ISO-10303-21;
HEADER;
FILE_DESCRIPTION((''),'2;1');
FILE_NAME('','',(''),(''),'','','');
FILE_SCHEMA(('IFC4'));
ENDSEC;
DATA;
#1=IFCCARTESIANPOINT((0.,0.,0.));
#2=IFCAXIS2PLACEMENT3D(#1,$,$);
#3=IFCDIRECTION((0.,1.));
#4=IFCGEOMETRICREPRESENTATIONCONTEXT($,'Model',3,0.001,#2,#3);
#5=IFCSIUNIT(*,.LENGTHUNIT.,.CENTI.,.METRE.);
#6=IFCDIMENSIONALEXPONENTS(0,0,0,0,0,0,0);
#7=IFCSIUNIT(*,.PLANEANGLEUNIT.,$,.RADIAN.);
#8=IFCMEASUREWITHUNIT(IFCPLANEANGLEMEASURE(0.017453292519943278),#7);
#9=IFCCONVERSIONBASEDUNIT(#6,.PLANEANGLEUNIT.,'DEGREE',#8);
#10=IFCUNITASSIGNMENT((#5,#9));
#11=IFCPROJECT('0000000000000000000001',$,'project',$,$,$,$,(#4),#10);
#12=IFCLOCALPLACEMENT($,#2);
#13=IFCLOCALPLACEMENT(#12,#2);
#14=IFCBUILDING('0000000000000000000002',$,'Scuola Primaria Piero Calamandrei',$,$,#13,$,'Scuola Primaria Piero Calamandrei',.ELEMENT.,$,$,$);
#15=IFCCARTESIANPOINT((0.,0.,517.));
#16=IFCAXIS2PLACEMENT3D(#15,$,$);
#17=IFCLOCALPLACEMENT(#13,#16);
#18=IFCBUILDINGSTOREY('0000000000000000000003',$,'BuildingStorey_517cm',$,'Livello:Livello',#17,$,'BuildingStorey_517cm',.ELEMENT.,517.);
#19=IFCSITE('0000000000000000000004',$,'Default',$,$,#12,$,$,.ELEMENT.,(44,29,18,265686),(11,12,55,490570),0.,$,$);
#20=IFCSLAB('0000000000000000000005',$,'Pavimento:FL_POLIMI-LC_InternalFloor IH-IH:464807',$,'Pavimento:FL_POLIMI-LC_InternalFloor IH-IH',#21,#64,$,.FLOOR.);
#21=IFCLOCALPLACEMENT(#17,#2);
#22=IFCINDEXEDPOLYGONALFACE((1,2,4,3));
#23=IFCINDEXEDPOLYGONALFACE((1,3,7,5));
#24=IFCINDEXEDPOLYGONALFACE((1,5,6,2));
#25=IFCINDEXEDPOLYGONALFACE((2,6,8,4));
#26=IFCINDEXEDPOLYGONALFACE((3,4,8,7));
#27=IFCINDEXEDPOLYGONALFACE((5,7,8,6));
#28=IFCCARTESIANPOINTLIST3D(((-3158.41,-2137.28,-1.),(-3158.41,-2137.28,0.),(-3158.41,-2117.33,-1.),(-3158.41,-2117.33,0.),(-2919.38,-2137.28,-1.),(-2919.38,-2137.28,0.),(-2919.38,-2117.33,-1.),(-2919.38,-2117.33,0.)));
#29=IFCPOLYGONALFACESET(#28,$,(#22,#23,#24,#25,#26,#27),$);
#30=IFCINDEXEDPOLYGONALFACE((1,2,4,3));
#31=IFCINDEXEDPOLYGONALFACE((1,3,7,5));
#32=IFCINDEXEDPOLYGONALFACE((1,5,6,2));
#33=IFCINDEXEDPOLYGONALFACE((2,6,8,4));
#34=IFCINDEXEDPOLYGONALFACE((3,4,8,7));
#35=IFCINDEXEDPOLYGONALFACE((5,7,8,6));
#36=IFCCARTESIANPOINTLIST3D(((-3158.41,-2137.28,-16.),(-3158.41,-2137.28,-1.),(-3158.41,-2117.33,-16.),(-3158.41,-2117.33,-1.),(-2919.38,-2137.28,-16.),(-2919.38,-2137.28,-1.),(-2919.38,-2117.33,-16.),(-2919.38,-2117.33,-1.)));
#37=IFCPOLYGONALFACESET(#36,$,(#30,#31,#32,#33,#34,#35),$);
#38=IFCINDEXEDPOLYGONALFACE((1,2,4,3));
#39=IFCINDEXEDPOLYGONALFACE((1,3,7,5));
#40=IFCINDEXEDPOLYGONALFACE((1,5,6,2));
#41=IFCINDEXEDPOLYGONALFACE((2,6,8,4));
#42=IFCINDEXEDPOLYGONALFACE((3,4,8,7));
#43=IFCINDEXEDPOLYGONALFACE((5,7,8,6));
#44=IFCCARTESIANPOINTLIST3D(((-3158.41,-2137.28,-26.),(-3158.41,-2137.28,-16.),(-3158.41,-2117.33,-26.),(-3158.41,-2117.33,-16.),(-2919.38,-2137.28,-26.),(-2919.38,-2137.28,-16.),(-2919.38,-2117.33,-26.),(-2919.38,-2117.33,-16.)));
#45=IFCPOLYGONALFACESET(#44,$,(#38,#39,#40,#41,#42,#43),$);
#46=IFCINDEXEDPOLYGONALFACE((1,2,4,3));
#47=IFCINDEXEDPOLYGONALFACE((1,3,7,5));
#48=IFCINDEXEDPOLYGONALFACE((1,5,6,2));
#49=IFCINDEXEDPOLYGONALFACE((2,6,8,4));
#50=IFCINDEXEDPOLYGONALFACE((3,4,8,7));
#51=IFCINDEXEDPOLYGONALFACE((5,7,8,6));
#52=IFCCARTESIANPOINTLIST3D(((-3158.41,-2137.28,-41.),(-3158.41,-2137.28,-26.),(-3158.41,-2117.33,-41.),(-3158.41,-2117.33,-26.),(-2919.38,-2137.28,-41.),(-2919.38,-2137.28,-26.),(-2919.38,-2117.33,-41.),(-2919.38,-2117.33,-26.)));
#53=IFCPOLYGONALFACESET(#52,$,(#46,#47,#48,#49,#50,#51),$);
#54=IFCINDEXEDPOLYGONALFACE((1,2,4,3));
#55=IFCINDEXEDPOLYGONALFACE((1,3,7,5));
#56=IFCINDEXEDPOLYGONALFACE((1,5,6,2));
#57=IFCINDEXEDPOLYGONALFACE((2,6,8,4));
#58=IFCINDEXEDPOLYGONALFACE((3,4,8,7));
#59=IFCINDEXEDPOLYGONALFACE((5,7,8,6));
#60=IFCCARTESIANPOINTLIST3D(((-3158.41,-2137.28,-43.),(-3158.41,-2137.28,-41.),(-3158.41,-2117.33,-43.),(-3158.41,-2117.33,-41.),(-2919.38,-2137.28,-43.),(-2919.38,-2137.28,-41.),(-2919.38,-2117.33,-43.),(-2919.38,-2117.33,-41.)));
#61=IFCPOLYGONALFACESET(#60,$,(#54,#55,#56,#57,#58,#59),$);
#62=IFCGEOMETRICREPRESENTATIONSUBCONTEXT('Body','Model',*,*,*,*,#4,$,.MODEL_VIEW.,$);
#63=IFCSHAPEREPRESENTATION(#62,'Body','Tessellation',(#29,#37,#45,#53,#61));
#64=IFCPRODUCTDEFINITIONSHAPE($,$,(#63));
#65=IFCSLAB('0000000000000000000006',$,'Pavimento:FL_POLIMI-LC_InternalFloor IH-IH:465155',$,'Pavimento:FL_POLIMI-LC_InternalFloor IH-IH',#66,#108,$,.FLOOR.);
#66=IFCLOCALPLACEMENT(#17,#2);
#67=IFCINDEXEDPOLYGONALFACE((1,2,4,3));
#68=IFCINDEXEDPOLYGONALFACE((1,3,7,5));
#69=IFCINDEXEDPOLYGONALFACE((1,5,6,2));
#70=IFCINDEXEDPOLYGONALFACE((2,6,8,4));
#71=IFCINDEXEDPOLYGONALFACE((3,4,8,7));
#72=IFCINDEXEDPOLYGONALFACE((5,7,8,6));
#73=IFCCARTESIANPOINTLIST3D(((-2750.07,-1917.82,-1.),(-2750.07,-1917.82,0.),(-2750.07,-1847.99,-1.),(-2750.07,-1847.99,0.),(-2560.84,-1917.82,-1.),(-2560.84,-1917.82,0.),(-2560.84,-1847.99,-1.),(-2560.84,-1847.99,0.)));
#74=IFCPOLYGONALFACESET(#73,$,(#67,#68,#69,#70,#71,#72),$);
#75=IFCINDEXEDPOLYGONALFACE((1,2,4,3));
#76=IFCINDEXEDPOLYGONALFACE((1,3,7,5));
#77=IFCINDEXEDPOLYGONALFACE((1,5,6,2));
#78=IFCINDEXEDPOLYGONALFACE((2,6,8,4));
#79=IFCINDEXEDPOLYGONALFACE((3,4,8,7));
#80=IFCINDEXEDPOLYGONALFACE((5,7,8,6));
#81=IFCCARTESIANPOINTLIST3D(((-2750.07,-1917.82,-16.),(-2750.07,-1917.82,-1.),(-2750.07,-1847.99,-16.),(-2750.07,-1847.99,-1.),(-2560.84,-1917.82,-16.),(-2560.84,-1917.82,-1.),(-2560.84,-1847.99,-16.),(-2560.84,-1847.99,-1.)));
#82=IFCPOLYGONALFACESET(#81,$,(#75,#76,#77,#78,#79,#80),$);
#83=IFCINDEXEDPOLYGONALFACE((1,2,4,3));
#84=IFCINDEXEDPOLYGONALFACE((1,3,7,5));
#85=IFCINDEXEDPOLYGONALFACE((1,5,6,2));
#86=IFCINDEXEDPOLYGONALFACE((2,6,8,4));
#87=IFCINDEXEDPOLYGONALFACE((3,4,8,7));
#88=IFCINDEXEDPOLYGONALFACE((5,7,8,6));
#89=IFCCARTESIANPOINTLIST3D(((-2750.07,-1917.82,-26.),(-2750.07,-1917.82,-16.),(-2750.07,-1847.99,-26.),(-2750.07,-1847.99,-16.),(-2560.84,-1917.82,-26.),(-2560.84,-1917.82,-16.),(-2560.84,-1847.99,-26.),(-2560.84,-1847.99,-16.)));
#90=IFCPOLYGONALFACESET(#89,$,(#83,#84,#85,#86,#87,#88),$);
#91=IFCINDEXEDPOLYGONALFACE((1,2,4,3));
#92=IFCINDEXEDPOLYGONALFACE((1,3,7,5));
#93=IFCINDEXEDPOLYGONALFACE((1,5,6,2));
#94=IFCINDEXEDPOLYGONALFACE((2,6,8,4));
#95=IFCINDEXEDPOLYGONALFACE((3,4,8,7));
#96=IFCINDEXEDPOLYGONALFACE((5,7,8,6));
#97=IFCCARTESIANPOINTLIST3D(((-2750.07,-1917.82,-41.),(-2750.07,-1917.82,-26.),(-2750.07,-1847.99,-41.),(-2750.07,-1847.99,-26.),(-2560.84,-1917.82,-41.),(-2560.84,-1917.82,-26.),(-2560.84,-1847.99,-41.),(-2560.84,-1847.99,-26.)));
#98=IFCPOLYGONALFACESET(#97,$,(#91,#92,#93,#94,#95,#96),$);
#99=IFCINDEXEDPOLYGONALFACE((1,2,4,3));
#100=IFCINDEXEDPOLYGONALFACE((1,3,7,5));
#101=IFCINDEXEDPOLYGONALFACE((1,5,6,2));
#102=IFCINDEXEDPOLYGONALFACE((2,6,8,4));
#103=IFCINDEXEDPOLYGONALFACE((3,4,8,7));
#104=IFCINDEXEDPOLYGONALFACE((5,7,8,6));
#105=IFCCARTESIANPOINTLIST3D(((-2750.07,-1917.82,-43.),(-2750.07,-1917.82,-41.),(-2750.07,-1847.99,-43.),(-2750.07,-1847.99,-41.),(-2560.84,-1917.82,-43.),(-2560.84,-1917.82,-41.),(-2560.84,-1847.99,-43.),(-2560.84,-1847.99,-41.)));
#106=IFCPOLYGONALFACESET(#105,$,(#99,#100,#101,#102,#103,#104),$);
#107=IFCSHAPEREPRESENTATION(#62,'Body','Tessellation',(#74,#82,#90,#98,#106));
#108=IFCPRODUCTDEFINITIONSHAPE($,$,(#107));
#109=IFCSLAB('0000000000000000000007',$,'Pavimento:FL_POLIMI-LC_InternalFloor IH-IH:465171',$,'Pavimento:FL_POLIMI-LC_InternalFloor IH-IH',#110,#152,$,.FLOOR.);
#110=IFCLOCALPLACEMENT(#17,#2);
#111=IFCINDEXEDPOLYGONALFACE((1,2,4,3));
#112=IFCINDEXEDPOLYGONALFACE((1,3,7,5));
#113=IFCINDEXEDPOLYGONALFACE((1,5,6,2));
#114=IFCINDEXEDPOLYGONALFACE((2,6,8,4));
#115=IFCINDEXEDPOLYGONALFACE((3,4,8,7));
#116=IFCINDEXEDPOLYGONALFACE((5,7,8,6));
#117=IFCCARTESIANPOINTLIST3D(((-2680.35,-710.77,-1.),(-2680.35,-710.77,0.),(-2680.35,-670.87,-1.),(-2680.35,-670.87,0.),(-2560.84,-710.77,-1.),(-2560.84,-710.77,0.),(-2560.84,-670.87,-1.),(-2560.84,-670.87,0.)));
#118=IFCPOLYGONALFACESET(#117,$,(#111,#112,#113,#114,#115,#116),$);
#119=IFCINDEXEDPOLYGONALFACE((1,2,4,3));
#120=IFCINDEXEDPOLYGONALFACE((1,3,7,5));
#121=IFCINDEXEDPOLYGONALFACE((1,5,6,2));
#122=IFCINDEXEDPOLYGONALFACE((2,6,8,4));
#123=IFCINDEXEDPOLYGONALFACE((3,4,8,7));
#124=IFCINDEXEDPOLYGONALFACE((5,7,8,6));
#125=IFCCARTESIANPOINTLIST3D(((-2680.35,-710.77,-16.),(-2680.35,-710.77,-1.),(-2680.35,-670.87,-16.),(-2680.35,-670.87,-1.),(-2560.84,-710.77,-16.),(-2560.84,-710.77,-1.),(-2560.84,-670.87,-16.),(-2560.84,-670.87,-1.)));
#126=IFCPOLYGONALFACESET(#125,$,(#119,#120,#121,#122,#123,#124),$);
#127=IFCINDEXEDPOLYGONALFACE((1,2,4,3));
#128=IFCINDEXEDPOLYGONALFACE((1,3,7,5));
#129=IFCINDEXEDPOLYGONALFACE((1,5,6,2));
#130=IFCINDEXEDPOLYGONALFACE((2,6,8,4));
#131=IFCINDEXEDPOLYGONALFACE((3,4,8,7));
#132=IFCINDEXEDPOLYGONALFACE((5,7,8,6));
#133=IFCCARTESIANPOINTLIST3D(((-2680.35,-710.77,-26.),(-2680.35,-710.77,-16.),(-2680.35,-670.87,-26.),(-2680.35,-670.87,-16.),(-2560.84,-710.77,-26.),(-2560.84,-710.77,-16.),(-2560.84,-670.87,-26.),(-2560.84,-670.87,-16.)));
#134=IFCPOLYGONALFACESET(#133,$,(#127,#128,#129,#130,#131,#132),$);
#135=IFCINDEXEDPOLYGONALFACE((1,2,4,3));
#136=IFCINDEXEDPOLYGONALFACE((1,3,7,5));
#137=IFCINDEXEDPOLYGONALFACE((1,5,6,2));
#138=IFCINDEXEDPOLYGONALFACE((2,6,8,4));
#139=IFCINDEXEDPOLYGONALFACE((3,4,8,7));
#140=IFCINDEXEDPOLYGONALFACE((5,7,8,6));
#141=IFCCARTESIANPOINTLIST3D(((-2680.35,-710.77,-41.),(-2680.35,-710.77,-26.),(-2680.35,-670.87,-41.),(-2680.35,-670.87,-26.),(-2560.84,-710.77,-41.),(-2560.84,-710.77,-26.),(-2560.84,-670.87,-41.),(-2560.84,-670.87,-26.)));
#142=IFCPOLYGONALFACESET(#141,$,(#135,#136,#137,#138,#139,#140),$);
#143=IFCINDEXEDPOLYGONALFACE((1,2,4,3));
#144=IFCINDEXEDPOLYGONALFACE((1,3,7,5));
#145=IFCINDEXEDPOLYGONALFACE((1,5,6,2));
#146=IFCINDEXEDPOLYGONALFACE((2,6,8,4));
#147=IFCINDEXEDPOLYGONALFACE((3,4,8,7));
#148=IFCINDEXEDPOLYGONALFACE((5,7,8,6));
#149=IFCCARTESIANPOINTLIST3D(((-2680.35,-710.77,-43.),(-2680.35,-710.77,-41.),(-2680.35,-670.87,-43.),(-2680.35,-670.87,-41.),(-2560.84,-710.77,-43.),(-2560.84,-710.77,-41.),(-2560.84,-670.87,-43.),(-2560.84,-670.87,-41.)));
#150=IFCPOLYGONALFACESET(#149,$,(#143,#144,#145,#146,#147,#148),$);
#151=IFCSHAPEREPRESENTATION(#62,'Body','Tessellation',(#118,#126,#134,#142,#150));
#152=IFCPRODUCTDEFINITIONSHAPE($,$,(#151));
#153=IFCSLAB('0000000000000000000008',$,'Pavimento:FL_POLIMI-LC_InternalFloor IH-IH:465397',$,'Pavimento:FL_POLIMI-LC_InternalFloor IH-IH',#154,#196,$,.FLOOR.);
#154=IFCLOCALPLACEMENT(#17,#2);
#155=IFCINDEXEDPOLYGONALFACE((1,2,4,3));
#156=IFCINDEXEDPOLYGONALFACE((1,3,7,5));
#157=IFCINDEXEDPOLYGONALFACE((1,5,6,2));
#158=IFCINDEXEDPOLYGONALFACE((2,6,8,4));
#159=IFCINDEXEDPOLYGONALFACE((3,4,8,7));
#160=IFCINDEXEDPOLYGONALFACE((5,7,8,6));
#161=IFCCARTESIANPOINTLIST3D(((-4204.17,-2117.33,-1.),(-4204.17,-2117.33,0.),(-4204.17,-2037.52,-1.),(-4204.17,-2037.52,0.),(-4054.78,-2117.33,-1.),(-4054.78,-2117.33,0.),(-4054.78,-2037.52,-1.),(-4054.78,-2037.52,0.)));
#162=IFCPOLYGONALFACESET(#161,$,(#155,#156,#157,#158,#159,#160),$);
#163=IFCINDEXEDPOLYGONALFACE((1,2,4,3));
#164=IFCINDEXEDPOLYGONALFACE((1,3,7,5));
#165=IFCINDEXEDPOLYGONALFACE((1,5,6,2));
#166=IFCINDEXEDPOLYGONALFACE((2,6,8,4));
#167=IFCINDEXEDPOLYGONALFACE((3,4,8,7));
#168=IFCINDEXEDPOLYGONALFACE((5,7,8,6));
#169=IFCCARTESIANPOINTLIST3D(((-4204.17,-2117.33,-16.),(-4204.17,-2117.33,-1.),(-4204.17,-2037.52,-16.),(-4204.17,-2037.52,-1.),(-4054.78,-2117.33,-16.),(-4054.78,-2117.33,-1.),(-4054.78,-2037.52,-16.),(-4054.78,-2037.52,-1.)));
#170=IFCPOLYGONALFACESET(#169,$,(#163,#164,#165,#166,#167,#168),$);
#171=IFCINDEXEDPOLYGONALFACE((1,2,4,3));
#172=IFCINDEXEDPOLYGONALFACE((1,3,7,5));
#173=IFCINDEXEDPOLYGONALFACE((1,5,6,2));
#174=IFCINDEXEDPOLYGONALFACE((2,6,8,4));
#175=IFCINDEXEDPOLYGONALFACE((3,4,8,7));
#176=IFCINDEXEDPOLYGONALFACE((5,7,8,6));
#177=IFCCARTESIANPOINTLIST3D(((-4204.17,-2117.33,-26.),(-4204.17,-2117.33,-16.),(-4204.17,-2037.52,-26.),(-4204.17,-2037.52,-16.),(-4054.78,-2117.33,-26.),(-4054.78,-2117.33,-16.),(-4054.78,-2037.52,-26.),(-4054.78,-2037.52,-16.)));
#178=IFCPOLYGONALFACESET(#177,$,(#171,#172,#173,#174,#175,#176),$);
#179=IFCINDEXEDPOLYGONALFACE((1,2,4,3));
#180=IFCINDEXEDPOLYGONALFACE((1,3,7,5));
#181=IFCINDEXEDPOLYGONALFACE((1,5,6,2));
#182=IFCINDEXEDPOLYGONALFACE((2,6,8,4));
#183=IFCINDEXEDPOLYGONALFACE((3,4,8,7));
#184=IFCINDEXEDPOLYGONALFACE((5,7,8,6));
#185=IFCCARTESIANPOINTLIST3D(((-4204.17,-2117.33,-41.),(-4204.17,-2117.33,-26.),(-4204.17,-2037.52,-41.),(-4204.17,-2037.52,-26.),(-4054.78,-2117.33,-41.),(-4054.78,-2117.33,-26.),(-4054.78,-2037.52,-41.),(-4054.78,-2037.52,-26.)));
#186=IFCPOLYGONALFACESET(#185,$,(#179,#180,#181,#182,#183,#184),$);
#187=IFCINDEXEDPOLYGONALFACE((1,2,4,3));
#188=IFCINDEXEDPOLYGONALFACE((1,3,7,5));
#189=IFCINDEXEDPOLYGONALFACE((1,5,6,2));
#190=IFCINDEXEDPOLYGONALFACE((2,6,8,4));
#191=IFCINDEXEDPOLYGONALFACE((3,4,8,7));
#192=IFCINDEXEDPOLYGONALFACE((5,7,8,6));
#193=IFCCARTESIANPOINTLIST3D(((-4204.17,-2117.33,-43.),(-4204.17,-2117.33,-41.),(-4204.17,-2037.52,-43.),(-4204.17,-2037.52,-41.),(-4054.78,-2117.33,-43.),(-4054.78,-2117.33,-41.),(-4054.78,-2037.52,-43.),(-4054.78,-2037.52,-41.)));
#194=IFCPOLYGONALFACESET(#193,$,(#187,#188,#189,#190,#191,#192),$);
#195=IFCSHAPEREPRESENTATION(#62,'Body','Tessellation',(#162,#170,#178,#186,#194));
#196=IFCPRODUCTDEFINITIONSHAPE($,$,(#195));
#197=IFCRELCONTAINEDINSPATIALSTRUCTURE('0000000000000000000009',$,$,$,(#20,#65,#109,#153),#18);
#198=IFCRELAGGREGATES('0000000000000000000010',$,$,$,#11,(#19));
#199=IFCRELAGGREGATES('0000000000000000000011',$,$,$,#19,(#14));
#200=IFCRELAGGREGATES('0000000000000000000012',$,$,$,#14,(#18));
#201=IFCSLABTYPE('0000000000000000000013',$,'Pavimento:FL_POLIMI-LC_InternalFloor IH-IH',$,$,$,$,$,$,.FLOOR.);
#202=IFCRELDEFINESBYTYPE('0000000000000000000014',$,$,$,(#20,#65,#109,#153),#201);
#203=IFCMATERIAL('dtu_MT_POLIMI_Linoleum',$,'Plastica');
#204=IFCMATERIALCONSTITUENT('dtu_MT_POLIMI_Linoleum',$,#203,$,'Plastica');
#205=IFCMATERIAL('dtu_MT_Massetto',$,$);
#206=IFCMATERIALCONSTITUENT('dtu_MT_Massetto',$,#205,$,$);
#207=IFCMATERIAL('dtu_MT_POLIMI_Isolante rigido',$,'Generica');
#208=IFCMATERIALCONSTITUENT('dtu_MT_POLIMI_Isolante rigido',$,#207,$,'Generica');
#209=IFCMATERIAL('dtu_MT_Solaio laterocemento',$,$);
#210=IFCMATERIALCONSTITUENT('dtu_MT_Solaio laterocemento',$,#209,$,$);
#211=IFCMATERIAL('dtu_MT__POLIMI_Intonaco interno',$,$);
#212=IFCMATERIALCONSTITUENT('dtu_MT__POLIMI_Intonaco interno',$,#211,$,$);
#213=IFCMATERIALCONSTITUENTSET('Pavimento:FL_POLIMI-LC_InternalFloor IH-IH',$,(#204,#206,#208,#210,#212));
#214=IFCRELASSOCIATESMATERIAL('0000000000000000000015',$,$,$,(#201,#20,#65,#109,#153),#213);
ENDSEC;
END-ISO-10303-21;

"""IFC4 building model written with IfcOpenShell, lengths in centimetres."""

from ifc_helpers import new_model, entity, si_unit, converted_unit, direction, frame, origin, place, context, subcontext, project, spatial, indexed_curve, outline, extrude, material, constituent, constituent_set, type_object, element, save


model = new_model("IFC4")

# Units and contexts
model_context = context("Model", 3, precision=0.001, world=origin(), true_north=direction((0.0, 1.0)))
body_context = subcontext(model_context, "Body", "Model", "MODEL_VIEW")
ifc_project = project(units=[si_unit("LENGTHUNIT", "METRE", prefix="CENTI"), converted_unit("PLANEANGLEUNIT", "DEGREE", entity("IfcPlaneAngleMeasure", 0.017453292519943278), si_unit("PLANEANGLEUNIT", "RADIAN"), dimensions=[0, 0, 0, 0, 0, 0, 0])], contexts=[model_context])

# Site, building, storey
site_placement = place(None, origin())
site = spatial("IfcSite", under=ifc_project, at=site_placement, Name="Default", CompositionType="ELEMENT", RefLatitude=(44, 29, 18, 265686), RefLongitude=(11, 12, 55, 490570), RefElevation=0.0)
building_placement = place(site_placement, origin())
building = spatial("IfcBuilding", under=site, at=building_placement, Name="Scuola Primaria Piero Calamandrei", LongName="Scuola Primaria Piero Calamandrei", CompositionType="ELEMENT")
storey_placement = place(building_placement, frame((0.0, 0.0, 517.0)))
storey = spatial("IfcBuildingStorey", under=building, at=storey_placement, Name="BuildingStorey_517cm", ObjectType="Livello:Livello", LongName="BuildingStorey_517cm", CompositionType="ELEMENT", Elevation=517.0)

# Slabs
ifc_material_1 = material(Name="dtu_MT_POLIMI_Linoleum", Category="Plastica")
ifc_constituent_1 = constituent(ifc_material_1, Name="dtu_MT_POLIMI_Linoleum", Category="Plastica")
ifc_material_2 = material(Name="dtu_MT_Massetto")
ifc_constituent_2 = constituent(ifc_material_2, Name="dtu_MT_Massetto")
ifc_material_3 = material(Name="dtu_MT_POLIMI_Isolante rigido", Category="Generica")
ifc_constituent_3 = constituent(ifc_material_3, Name="dtu_MT_POLIMI_Isolante rigido", Category="Generica")
ifc_material_4 = material(Name="dtu_MT_Solaio laterocemento")
ifc_constituent_4 = constituent(ifc_material_4, Name="dtu_MT_Solaio laterocemento")
ifc_material_5 = material(Name="dtu_MT__POLIMI_Intonaco interno")
ifc_constituent_5 = constituent(ifc_material_5, Name="dtu_MT__POLIMI_Intonaco interno")
ifc_constituent_set_1 = constituent_set(constituents=[ifc_constituent_1, ifc_constituent_2, ifc_constituent_3, ifc_constituent_4, ifc_constituent_5], Name="Pavimento:FL_POLIMI-LC_InternalFloor IH-IH")
slab_type_1 = type_object("IfcSlabType", Name="Pavimento:FL_POLIMI-LC_InternalFloor IH-IH", PredefinedType="FLOOR", material=ifc_constituent_set_1)
slab_1_placement = place(storey_placement, origin())
element("IfcSlab", 1, at=slab_1_placement, inside=storey, type_object=slab_type_1, material=ifc_constituent_set_1, Name="Pavimento:FL_POLIMI-LC_InternalFloor IH-IH:464807", ObjectType="Pavimento:FL_POLIMI-LC_InternalFloor IH-IH", PredefinedType="FLOOR", context=body_context, shape_type="SweptSolid", body=[
    extrude(outline(indexed_curve([(-119.52, -9.98), (119.52, -9.98), (119.52, 9.98), (-119.52, 9.98), (-119.52, -9.98)], self_intersect=False)), frame((-3038.9, -2127.3, -1.0)), (0.0, 0.0, 1.0), 1.0),
    extrude(outline(indexed_curve([(-119.52, -9.98), (119.52, -9.98), (119.52, 9.98), (-119.52, 9.98), (-119.52, -9.98)], self_intersect=False)), frame((-3038.9, -2127.3, -16.0)), (0.0, 0.0, 1.0), 15.0),
    extrude(outline(indexed_curve([(-119.52, -9.98), (119.52, -9.98), (119.52, 9.98), (-119.52, 9.98), (-119.52, -9.98)], self_intersect=False)), frame((-3038.9, -2127.3, -26.0)), (0.0, 0.0, 1.0), 10.0),
    extrude(outline(indexed_curve([(-119.52, -9.98), (119.52, -9.98), (119.52, 9.98), (-119.52, 9.98), (-119.52, -9.98)], self_intersect=False)), frame((-3038.9, -2127.3, -41.0)), (0.0, 0.0, 1.0), 15.0),
    extrude(outline(indexed_curve([(-119.52, -9.98), (119.52, -9.98), (119.52, 9.98), (-119.52, 9.98), (-119.52, -9.98)], self_intersect=False)), frame((-3038.9, -2127.3, -43.0)), (0.0, 0.0, 1.0), 2.0),
])
slab_2_placement = place(storey_placement, origin())
element("IfcSlab", 2, at=slab_2_placement, inside=storey, type_object=slab_type_1, material=ifc_constituent_set_1, Name="Pavimento:FL_POLIMI-LC_InternalFloor IH-IH:465155", ObjectType="Pavimento:FL_POLIMI-LC_InternalFloor IH-IH", PredefinedType="FLOOR", context=body_context, shape_type="SweptSolid", body=[
    extrude(outline(indexed_curve([(-34.91, -94.62), (34.91, -94.62), (34.91, 94.62), (-34.91, 94.62), (-34.91, -94.62)], self_intersect=False)), frame((-2655.45, -1882.9, -1.0), z_axis=(0.0, 0.0, 1.0), x_axis=(0.0, 1.0, 0.0)), (0.0, 0.0, 1.0), 1.0),
    extrude(outline(indexed_curve([(-34.91, -94.62), (34.91, -94.62), (34.91, 94.62), (-34.91, 94.62), (-34.91, -94.62)], self_intersect=False)), frame((-2655.45, -1882.9, -16.0), z_axis=(0.0, 0.0, 1.0), x_axis=(0.0, 1.0, 0.0)), (0.0, 0.0, 1.0), 15.0),
    extrude(outline(indexed_curve([(-34.91, -94.62), (34.91, -94.62), (34.91, 94.62), (-34.91, 94.62), (-34.91, -94.62)], self_intersect=False)), frame((-2655.45, -1882.9, -26.0), z_axis=(0.0, 0.0, 1.0), x_axis=(0.0, 1.0, 0.0)), (0.0, 0.0, 1.0), 10.0),
    extrude(outline(indexed_curve([(-34.91, -94.62), (34.91, -94.62), (34.91, 94.62), (-34.91, 94.62), (-34.91, -94.62)], self_intersect=False)), frame((-2655.45, -1882.9, -41.0), z_axis=(0.0, 0.0, 1.0), x_axis=(0.0, 1.0, 0.0)), (0.0, 0.0, 1.0), 15.0),
    extrude(outline(indexed_curve([(-34.91, -94.62), (34.91, -94.62), (34.91, 94.62), (-34.91, 94.62), (-34.91, -94.62)], self_intersect=False)), frame((-2655.45, -1882.9, -43.0), z_axis=(0.0, 0.0, 1.0), x_axis=(0.0, 1.0, 0.0)), (0.0, 0.0, 1.0), 2.0),
])
slab_3_placement = place(storey_placement, origin())
element("IfcSlab", 3, at=slab_3_placement, inside=storey, type_object=slab_type_1, material=ifc_constituent_set_1, Name="Pavimento:FL_POLIMI-LC_InternalFloor IH-IH:465171", ObjectType="Pavimento:FL_POLIMI-LC_InternalFloor IH-IH", PredefinedType="FLOOR", context=body_context, shape_type="SweptSolid", body=[
    extrude(outline(indexed_curve([(-59.76, -19.95), (59.76, -19.95), (59.76, 19.95), (-59.76, 19.95), (-59.76, -19.95)], self_intersect=False)), frame((-2620.59, -690.82, -1.0)), (0.0, 0.0, 1.0), 1.0),
    extrude(outline(indexed_curve([(-59.76, -19.95), (59.76, -19.95), (59.76, 19.95), (-59.76, 19.95), (-59.76, -19.95)], self_intersect=False)), frame((-2620.59, -690.82, -16.0)), (0.0, 0.0, 1.0), 15.0),
    extrude(outline(indexed_curve([(-59.76, -19.95), (59.76, -19.95), (59.76, 19.95), (-59.76, 19.95), (-59.76, -19.95)], self_intersect=False)), frame((-2620.59, -690.82, -26.0)), (0.0, 0.0, 1.0), 10.0),
    extrude(outline(indexed_curve([(-59.76, -19.95), (59.76, -19.95), (59.76, 19.95), (-59.76, 19.95), (-59.76, -19.95)], self_intersect=False)), frame((-2620.59, -690.82, -41.0)), (0.0, 0.0, 1.0), 15.0),
    extrude(outline(indexed_curve([(-59.76, -19.95), (59.76, -19.95), (59.76, 19.95), (-59.76, 19.95), (-59.76, -19.95)], self_intersect=False)), frame((-2620.59, -690.82, -43.0)), (0.0, 0.0, 1.0), 2.0),
])
slab_4_placement = place(storey_placement, origin())
element("IfcSlab", 4, at=slab_4_placement, inside=storey, type_object=slab_type_1, material=ifc_constituent_set_1, Name="Pavimento:FL_POLIMI-LC_InternalFloor IH-IH:465397", ObjectType="Pavimento:FL_POLIMI-LC_InternalFloor IH-IH", PredefinedType="FLOOR", context=body_context, shape_type="SweptSolid", body=[
    extrude(outline(indexed_curve([(-74.7, -39.9), (74.7, -39.9), (74.7, 39.9), (-74.7, 39.9), (-74.7, -39.9)], self_intersect=False)), frame((-4129.48, -2077.42, -1.0), z_axis=(0.0, 0.0, 1.0), x_axis=(-1.0, 0.0, 0.0)), (0.0, 0.0, 1.0), 1.0),
    extrude(outline(indexed_curve([(-74.7, -39.9), (74.7, -39.9), (74.7, 39.9), (-74.7, 39.9), (-74.7, -39.9)], self_intersect=False)), frame((-4129.48, -2077.42, -16.0), z_axis=(0.0, 0.0, 1.0), x_axis=(-1.0, 0.0, 0.0)), (0.0, 0.0, 1.0), 15.0),
    extrude(outline(indexed_curve([(-74.7, -39.9), (74.7, -39.9), (74.7, 39.9), (-74.7, 39.9), (-74.7, -39.9)], self_intersect=False)), frame((-4129.48, -2077.42, -26.0), z_axis=(0.0, 0.0, 1.0), x_axis=(-1.0, 0.0, 0.0)), (0.0, 0.0, 1.0), 10.0),
    extrude(outline(indexed_curve([(-74.7, -39.9), (74.7, -39.9), (74.7, 39.9), (-74.7, 39.9), (-74.7, -39.9)], self_intersect=False)), frame((-4129.48, -2077.42, -41.0), z_axis=(0.0, 0.0, 1.0), x_axis=(-1.0, 0.0, 0.0)), (0.0, 0.0, 1.0), 15.0),
    extrude(outline(indexed_curve([(-74.7, -39.9), (74.7, -39.9), (74.7, 39.9), (-74.7, 39.9), (-74.7, -39.9)], self_intersect=False)), frame((-4129.48, -2077.42, -43.0), z_axis=(0.0, 0.0, 1.0), x_axis=(-1.0, 0.0, 0.0)), (0.0, 0.0, 1.0), 2.0),
])

save(model, "model.ifc")
